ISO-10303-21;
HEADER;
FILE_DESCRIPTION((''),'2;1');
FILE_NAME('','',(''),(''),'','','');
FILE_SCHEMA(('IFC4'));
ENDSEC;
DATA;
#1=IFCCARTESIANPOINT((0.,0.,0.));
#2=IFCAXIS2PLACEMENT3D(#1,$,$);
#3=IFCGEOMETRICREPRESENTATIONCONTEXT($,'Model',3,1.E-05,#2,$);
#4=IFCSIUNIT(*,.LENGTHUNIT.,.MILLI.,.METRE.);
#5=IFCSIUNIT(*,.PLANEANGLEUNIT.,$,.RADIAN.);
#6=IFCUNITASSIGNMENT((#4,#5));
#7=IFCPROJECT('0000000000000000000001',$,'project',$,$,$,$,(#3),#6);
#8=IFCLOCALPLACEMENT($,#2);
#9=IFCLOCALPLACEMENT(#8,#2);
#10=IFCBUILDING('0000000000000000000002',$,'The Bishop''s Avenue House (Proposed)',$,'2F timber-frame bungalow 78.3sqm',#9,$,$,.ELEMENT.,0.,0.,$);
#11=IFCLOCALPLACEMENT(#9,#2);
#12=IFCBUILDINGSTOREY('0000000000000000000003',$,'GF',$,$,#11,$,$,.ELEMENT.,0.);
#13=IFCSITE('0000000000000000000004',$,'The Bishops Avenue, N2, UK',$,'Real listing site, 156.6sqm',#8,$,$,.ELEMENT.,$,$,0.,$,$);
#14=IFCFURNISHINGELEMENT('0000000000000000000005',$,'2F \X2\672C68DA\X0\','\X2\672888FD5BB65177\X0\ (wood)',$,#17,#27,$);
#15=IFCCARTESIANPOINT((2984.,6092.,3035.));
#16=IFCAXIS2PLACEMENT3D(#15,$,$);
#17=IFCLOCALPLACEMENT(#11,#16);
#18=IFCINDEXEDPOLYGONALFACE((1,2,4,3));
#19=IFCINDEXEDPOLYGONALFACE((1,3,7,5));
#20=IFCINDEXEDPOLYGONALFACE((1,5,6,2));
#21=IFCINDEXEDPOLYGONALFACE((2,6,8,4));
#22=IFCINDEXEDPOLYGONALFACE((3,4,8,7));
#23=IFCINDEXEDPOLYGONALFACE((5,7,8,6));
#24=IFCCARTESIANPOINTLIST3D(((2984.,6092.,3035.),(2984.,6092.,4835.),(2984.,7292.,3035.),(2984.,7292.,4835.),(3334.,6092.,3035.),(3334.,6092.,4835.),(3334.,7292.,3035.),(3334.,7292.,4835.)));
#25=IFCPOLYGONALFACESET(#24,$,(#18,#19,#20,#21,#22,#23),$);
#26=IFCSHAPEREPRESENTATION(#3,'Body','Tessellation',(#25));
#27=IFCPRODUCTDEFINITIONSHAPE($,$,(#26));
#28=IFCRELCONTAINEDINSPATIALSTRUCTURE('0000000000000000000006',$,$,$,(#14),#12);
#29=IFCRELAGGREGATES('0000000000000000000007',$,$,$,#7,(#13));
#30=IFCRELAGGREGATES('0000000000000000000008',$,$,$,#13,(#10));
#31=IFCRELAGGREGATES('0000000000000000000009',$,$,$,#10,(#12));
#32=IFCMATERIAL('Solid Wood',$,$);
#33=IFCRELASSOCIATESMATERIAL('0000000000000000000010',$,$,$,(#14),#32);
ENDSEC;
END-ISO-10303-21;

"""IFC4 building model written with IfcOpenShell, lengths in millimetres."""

from ifc_helpers import new_model, si_unit, frame, frame_2d, origin, place, context, project, spatial, rectangle, extrude, material, element, save


model = new_model("IFC4")

# Units and contexts
model_context = context("Model", 3, precision=1e-05, world=origin())
ifc_project = project(units=[si_unit("LENGTHUNIT", "METRE", prefix="MILLI"), si_unit("PLANEANGLEUNIT", "RADIAN")], contexts=[model_context])

# Site, building, storey
site_placement = place(None, origin())
site = spatial("IfcSite", under=ifc_project, at=site_placement, Name="The Bishops Avenue, N2, UK", ObjectType="Real listing site, 156.6sqm", CompositionType="ELEMENT", RefElevation=0.0)
building_placement = place(site_placement, origin())
building = spatial("IfcBuilding", under=site, at=building_placement, Name="The Bishop's Avenue House (Proposed)", ObjectType="2F timber-frame bungalow 78.3sqm", CompositionType="ELEMENT", ElevationOfRefHeight=0.0, ElevationOfTerrain=0.0)
storey_placement = place(building_placement, origin())
storey = spatial("IfcBuildingStorey", under=building, at=storey_placement, Name="GF", CompositionType="ELEMENT", Elevation=0.0)

# Shared definitions
ifc_material_1 = material(Name="Solid Wood")

# Furnishing element
furnishing_1_placement = place(storey_placement, frame((2984.0, 6092.0, 3035.0)))
element("IfcFurnishingElement", 1, at=furnishing_1_placement, inside=storey, material=ifc_material_1, Name="2F 本棚", Description="木製家具 (wood)", context=model_context, shape_type="SweptSolid", body=[
    extrude(rectangle(XDim=350.0, YDim=1200.0, at=frame_2d((175.0, 600.0))), frame((2984.0, 6092.0, 3035.0)), (0.0, 0.0, 1.0), 1800.0),
])

save(model, "model.ifc")
